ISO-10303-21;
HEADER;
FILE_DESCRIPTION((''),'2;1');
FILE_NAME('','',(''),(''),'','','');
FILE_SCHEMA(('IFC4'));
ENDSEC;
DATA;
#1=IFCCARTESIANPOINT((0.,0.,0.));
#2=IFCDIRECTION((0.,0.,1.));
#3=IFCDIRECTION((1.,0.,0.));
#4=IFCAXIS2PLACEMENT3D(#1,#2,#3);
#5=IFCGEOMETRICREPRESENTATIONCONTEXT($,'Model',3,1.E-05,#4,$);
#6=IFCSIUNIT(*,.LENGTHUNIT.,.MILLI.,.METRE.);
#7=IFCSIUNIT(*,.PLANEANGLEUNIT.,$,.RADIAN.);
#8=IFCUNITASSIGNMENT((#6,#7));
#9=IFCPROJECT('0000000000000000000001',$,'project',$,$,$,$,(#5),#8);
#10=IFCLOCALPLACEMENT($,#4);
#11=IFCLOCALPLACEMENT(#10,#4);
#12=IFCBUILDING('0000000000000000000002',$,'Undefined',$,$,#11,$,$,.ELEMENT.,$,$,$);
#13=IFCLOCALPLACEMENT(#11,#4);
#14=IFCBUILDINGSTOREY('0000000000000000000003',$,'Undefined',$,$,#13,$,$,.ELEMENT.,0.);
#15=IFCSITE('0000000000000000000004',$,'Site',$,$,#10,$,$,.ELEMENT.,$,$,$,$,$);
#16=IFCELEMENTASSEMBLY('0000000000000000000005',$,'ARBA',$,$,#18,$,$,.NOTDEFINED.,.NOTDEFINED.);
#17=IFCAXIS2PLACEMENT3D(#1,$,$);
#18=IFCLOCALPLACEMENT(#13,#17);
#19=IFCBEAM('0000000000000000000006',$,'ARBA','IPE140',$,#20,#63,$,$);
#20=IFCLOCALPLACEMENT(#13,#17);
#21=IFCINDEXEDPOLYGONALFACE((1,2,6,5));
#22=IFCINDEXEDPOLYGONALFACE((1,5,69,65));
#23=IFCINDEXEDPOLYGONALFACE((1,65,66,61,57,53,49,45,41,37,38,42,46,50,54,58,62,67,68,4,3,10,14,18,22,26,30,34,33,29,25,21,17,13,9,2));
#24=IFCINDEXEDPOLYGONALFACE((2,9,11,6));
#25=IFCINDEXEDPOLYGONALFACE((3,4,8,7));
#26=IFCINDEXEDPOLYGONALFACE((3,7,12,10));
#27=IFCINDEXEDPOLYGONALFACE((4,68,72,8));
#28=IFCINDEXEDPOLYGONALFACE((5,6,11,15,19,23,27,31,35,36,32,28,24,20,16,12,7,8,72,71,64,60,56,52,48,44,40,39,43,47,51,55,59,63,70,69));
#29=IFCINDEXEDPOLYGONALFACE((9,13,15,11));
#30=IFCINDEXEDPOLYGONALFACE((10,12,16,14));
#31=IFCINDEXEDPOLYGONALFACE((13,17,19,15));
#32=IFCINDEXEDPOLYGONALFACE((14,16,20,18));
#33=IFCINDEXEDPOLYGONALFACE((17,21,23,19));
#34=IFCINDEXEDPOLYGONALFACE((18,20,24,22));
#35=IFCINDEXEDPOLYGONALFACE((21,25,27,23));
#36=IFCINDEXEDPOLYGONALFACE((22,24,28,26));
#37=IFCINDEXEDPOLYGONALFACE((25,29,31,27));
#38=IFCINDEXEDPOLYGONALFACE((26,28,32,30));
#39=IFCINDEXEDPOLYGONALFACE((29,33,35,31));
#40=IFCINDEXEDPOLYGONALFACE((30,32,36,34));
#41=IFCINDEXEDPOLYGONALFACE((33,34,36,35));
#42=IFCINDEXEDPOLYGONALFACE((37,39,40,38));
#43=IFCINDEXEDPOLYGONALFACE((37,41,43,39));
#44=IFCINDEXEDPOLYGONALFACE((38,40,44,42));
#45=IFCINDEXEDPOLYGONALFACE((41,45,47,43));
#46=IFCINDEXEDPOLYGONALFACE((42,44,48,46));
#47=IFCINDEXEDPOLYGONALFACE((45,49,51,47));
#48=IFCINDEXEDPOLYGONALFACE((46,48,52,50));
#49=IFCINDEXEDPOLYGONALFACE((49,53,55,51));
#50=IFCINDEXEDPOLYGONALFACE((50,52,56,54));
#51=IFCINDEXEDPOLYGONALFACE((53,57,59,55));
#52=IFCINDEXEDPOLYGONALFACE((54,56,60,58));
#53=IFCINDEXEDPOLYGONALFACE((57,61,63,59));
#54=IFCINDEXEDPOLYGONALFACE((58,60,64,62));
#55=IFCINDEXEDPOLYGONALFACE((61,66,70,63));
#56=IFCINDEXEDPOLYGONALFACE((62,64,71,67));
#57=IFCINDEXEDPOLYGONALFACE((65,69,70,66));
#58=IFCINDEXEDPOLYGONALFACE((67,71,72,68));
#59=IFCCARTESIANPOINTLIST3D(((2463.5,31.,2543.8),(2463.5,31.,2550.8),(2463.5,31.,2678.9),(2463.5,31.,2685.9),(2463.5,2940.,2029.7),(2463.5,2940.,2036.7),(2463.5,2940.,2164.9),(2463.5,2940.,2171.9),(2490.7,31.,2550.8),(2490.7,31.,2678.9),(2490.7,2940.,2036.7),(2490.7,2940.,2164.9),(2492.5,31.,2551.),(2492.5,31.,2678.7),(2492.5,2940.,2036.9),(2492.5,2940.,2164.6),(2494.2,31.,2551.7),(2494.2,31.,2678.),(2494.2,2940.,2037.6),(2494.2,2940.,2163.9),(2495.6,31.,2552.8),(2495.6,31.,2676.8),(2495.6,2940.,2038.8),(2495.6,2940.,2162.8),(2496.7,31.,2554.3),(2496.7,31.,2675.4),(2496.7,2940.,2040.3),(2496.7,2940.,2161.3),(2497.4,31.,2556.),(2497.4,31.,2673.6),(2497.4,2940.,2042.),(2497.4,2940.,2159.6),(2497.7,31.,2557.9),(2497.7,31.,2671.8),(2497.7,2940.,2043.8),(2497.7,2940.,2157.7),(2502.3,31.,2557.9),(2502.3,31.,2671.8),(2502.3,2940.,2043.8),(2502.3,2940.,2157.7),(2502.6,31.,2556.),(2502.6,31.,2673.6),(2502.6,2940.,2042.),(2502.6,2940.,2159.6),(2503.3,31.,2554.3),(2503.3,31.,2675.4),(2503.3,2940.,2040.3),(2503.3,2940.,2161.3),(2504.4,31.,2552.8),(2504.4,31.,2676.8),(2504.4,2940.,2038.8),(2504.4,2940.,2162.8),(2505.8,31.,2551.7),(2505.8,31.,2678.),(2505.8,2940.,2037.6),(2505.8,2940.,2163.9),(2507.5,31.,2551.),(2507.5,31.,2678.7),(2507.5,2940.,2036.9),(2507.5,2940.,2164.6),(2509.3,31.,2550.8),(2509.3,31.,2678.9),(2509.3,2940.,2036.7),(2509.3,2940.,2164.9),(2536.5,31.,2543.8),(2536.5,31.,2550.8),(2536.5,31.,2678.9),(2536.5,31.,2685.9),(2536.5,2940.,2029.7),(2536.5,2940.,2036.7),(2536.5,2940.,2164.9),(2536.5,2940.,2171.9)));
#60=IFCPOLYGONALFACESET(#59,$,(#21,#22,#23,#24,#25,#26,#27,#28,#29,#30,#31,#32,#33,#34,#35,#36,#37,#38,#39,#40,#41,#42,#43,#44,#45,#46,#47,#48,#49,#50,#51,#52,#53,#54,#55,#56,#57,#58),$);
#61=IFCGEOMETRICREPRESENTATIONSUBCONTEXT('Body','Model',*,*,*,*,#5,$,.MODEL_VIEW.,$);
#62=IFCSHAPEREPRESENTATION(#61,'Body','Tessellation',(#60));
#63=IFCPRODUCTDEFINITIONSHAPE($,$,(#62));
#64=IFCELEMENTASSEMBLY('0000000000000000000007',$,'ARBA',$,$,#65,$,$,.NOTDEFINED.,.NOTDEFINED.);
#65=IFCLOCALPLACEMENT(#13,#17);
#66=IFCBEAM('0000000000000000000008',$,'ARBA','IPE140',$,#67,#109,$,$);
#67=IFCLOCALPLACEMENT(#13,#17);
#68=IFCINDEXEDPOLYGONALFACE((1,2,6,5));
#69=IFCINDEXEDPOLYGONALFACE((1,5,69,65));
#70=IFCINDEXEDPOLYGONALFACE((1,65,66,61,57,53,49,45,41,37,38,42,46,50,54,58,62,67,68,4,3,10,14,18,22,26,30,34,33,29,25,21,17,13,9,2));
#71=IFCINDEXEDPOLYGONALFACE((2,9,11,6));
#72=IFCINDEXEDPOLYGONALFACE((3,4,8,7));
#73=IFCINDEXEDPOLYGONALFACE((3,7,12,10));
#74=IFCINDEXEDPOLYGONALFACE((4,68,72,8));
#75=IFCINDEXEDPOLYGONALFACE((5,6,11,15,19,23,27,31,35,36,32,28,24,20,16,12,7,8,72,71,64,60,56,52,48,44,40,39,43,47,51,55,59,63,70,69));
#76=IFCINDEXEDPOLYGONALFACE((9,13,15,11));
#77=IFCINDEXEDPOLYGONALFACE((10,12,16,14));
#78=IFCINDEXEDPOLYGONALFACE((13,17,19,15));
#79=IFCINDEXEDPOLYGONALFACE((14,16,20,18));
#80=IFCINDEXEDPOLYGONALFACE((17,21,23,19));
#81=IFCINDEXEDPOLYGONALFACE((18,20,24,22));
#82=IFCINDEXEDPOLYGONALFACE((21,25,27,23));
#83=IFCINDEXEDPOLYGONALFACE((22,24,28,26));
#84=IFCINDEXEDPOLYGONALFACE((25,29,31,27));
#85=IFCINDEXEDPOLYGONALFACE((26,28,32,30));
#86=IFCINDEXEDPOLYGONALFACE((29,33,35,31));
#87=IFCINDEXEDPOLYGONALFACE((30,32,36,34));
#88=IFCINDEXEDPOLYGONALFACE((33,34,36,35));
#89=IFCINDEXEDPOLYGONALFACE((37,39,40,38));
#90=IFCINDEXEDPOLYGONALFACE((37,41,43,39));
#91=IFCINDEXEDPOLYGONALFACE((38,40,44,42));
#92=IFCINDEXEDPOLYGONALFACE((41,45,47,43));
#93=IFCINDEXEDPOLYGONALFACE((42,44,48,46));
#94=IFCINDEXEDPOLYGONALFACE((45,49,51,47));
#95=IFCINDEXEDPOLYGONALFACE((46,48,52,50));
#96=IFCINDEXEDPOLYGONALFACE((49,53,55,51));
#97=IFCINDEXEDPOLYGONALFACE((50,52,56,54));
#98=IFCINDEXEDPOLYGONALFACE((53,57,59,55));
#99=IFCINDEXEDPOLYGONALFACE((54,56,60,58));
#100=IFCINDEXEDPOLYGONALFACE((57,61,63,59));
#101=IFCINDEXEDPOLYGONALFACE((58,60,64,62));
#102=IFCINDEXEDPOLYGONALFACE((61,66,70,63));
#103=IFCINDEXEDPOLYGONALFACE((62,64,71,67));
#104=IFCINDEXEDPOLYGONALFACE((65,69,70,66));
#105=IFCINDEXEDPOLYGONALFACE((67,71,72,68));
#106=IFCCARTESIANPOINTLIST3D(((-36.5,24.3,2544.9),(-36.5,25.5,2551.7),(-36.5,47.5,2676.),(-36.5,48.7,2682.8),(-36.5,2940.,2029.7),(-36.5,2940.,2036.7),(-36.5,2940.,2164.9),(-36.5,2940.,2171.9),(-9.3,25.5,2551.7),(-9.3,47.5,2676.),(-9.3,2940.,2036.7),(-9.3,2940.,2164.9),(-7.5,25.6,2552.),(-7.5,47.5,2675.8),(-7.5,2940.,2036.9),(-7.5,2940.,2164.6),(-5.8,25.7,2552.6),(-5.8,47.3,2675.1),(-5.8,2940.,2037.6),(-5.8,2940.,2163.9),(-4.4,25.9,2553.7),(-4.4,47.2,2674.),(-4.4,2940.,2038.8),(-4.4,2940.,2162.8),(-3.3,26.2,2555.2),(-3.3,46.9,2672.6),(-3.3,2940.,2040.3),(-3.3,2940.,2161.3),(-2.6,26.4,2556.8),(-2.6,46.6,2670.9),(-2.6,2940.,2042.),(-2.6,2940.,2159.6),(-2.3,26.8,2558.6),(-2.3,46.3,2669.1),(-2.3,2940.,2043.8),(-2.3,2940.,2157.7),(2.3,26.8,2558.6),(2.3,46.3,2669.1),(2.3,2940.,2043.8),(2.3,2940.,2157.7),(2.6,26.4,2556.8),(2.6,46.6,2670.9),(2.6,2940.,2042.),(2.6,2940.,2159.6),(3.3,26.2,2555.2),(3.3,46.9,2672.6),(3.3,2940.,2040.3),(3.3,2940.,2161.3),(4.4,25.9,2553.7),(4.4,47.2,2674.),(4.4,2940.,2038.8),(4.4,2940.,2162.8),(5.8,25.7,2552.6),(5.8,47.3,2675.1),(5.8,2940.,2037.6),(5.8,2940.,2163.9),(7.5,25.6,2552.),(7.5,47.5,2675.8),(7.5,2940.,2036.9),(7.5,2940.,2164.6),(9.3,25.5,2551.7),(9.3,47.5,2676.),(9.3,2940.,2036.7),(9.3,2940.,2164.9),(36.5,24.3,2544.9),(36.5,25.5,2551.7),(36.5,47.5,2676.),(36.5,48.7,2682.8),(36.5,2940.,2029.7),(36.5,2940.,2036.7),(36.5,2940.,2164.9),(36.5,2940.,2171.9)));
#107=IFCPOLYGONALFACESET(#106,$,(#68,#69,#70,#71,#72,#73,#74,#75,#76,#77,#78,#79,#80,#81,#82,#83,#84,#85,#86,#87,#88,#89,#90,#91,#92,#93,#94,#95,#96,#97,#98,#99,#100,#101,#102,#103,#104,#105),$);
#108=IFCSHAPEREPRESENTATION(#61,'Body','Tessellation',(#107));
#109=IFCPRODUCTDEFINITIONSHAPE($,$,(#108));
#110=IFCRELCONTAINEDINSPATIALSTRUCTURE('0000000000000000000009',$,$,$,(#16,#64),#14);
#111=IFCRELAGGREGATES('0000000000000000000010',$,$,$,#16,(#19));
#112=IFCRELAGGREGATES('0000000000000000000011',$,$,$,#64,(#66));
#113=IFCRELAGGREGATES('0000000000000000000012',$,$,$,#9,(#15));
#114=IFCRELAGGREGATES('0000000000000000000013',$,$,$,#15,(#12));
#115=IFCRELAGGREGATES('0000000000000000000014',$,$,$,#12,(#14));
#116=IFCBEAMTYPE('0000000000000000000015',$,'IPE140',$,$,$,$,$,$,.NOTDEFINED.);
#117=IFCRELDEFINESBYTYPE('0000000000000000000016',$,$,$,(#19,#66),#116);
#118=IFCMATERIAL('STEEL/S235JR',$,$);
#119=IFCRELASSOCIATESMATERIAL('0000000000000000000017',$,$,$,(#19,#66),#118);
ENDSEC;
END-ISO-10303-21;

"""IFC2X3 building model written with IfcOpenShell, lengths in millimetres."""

from ifc_helpers import new_model, si_unit, frame, origin_with_axes, origin_2d_with_axis, place, context, subcontext, project, spatial, i_section, extrude, clip, halfspace, material, type_object, element, aggregate, save


model = new_model("IFC2X3")

# Units and contexts
model_context = context("Model", 3, precision=1e-05, world=origin_with_axes())
body_context = subcontext(model_context, "Body", "Model", "MODEL_VIEW")
ifc_project = project(units=[si_unit("LENGTHUNIT", "METRE", prefix="MILLI"), si_unit("PLANEANGLEUNIT", "RADIAN")], contexts=[model_context])

# Site, building, storey
site_placement = place(None, origin_with_axes())
site = spatial("IfcSite", under=ifc_project, at=site_placement, Name="Site", CompositionType="ELEMENT")
building_placement = place(site_placement, origin_with_axes())
building = spatial("IfcBuilding", under=site, at=building_placement, Name="Undefined", CompositionType="ELEMENT")
storey_placement = place(building_placement, origin_with_axes())
storey = spatial("IfcBuildingStorey", under=building, at=storey_placement, Name="Undefined", CompositionType="ELEMENT", Elevation=0.0)

# Shared definitions
ifc_material_1 = material(Name="STEEL/S235JR")

# Element assemblies, beams
assembly_1_placement = place(storey_placement, origin_with_axes())
assembly_1 = element("IfcElementAssembly", 1, at=assembly_1_placement, inside=storey, Name="ARBA", AssemblyPlace="NOTDEFINED", PredefinedType="NOTDEFINED")
beam_type = type_object("IfcBeamType", Name="IPE140", PredefinedType="NOTDEFINED")
beam_1_placement = place(assembly_1_placement, frame((2500.0, 18.8, 2617.0), z_axis=(0.0, 0.174019, 0.984742), x_axis=(0.0, 0.984742, -0.174019)))
beam_1 = element("IfcBeam", 2, at=beam_1_placement, type_object=beam_type, material=ifc_material_1, Name="ARBA", Description="IPE140", context=body_context, shape_type="Clipping", body=[
    clip(clip(extrude(i_section(OverallWidth=73.0, OverallDepth=140.0, WebThickness=4.7, FlangeThickness=6.9, FilletRadius=7.0, at=origin_2d_with_axis()), frame((3027.4, 0.0, 0.0), z_axis=(-1.0, 0.0, 0.0), x_axis=(0.0, -1.0, 0.0)), (0.0, 0.0, 1.0), 3027.4), halfspace(frame((24.7, 36.5, -70.0), z_axis=(-0.984742, 0.0, -0.174019), x_axis=(-0.174019, 0.0, 0.984742)), False)), halfspace(frame((2978.8, 0.0, -70.0), z_axis=(-0.984742, 0.0, -0.174019), x_axis=(0.0, 1.0, 0.0)), True)),
])
aggregate(assembly_1, [beam_1])
assembly_2_placement = place(storey_placement, origin_with_axes())
assembly_2 = element("IfcElementAssembly", 3, at=assembly_2_placement, inside=storey, Name="ARBA", AssemblyPlace="NOTDEFINED", PredefinedType="NOTDEFINED")
beam_2_placement = place(assembly_2_placement, frame((0.0, 36.5, 2613.9), z_axis=(0.0, 0.174019, 0.984742), x_axis=(0.0, 0.984742, -0.174019)))
beam_2 = element("IfcBeam", 4, at=beam_2_placement, type_object=beam_type, material=ifc_material_1, Name="ARBA", Description="IPE140", context=body_context, shape_type="Clipping", body=[
    clip(extrude(i_section(OverallWidth=73.0, OverallDepth=140.0, WebThickness=4.7, FlangeThickness=6.9, FilletRadius=7.0, at=origin_2d_with_axis()), frame((3009.4, 0.0, 0.0), z_axis=(-1.0, 0.0, 0.0), x_axis=(0.0, -1.0, 0.0)), (0.0, 0.0, 1.0), 3009.4), halfspace(frame((2960.8, 0.0, -70.0), z_axis=(-0.984742, 0.0, -0.174019), x_axis=(0.0, 1.0, 0.0)), True)),
])
aggregate(assembly_2, [beam_2])

save(model, "model.ifc")
